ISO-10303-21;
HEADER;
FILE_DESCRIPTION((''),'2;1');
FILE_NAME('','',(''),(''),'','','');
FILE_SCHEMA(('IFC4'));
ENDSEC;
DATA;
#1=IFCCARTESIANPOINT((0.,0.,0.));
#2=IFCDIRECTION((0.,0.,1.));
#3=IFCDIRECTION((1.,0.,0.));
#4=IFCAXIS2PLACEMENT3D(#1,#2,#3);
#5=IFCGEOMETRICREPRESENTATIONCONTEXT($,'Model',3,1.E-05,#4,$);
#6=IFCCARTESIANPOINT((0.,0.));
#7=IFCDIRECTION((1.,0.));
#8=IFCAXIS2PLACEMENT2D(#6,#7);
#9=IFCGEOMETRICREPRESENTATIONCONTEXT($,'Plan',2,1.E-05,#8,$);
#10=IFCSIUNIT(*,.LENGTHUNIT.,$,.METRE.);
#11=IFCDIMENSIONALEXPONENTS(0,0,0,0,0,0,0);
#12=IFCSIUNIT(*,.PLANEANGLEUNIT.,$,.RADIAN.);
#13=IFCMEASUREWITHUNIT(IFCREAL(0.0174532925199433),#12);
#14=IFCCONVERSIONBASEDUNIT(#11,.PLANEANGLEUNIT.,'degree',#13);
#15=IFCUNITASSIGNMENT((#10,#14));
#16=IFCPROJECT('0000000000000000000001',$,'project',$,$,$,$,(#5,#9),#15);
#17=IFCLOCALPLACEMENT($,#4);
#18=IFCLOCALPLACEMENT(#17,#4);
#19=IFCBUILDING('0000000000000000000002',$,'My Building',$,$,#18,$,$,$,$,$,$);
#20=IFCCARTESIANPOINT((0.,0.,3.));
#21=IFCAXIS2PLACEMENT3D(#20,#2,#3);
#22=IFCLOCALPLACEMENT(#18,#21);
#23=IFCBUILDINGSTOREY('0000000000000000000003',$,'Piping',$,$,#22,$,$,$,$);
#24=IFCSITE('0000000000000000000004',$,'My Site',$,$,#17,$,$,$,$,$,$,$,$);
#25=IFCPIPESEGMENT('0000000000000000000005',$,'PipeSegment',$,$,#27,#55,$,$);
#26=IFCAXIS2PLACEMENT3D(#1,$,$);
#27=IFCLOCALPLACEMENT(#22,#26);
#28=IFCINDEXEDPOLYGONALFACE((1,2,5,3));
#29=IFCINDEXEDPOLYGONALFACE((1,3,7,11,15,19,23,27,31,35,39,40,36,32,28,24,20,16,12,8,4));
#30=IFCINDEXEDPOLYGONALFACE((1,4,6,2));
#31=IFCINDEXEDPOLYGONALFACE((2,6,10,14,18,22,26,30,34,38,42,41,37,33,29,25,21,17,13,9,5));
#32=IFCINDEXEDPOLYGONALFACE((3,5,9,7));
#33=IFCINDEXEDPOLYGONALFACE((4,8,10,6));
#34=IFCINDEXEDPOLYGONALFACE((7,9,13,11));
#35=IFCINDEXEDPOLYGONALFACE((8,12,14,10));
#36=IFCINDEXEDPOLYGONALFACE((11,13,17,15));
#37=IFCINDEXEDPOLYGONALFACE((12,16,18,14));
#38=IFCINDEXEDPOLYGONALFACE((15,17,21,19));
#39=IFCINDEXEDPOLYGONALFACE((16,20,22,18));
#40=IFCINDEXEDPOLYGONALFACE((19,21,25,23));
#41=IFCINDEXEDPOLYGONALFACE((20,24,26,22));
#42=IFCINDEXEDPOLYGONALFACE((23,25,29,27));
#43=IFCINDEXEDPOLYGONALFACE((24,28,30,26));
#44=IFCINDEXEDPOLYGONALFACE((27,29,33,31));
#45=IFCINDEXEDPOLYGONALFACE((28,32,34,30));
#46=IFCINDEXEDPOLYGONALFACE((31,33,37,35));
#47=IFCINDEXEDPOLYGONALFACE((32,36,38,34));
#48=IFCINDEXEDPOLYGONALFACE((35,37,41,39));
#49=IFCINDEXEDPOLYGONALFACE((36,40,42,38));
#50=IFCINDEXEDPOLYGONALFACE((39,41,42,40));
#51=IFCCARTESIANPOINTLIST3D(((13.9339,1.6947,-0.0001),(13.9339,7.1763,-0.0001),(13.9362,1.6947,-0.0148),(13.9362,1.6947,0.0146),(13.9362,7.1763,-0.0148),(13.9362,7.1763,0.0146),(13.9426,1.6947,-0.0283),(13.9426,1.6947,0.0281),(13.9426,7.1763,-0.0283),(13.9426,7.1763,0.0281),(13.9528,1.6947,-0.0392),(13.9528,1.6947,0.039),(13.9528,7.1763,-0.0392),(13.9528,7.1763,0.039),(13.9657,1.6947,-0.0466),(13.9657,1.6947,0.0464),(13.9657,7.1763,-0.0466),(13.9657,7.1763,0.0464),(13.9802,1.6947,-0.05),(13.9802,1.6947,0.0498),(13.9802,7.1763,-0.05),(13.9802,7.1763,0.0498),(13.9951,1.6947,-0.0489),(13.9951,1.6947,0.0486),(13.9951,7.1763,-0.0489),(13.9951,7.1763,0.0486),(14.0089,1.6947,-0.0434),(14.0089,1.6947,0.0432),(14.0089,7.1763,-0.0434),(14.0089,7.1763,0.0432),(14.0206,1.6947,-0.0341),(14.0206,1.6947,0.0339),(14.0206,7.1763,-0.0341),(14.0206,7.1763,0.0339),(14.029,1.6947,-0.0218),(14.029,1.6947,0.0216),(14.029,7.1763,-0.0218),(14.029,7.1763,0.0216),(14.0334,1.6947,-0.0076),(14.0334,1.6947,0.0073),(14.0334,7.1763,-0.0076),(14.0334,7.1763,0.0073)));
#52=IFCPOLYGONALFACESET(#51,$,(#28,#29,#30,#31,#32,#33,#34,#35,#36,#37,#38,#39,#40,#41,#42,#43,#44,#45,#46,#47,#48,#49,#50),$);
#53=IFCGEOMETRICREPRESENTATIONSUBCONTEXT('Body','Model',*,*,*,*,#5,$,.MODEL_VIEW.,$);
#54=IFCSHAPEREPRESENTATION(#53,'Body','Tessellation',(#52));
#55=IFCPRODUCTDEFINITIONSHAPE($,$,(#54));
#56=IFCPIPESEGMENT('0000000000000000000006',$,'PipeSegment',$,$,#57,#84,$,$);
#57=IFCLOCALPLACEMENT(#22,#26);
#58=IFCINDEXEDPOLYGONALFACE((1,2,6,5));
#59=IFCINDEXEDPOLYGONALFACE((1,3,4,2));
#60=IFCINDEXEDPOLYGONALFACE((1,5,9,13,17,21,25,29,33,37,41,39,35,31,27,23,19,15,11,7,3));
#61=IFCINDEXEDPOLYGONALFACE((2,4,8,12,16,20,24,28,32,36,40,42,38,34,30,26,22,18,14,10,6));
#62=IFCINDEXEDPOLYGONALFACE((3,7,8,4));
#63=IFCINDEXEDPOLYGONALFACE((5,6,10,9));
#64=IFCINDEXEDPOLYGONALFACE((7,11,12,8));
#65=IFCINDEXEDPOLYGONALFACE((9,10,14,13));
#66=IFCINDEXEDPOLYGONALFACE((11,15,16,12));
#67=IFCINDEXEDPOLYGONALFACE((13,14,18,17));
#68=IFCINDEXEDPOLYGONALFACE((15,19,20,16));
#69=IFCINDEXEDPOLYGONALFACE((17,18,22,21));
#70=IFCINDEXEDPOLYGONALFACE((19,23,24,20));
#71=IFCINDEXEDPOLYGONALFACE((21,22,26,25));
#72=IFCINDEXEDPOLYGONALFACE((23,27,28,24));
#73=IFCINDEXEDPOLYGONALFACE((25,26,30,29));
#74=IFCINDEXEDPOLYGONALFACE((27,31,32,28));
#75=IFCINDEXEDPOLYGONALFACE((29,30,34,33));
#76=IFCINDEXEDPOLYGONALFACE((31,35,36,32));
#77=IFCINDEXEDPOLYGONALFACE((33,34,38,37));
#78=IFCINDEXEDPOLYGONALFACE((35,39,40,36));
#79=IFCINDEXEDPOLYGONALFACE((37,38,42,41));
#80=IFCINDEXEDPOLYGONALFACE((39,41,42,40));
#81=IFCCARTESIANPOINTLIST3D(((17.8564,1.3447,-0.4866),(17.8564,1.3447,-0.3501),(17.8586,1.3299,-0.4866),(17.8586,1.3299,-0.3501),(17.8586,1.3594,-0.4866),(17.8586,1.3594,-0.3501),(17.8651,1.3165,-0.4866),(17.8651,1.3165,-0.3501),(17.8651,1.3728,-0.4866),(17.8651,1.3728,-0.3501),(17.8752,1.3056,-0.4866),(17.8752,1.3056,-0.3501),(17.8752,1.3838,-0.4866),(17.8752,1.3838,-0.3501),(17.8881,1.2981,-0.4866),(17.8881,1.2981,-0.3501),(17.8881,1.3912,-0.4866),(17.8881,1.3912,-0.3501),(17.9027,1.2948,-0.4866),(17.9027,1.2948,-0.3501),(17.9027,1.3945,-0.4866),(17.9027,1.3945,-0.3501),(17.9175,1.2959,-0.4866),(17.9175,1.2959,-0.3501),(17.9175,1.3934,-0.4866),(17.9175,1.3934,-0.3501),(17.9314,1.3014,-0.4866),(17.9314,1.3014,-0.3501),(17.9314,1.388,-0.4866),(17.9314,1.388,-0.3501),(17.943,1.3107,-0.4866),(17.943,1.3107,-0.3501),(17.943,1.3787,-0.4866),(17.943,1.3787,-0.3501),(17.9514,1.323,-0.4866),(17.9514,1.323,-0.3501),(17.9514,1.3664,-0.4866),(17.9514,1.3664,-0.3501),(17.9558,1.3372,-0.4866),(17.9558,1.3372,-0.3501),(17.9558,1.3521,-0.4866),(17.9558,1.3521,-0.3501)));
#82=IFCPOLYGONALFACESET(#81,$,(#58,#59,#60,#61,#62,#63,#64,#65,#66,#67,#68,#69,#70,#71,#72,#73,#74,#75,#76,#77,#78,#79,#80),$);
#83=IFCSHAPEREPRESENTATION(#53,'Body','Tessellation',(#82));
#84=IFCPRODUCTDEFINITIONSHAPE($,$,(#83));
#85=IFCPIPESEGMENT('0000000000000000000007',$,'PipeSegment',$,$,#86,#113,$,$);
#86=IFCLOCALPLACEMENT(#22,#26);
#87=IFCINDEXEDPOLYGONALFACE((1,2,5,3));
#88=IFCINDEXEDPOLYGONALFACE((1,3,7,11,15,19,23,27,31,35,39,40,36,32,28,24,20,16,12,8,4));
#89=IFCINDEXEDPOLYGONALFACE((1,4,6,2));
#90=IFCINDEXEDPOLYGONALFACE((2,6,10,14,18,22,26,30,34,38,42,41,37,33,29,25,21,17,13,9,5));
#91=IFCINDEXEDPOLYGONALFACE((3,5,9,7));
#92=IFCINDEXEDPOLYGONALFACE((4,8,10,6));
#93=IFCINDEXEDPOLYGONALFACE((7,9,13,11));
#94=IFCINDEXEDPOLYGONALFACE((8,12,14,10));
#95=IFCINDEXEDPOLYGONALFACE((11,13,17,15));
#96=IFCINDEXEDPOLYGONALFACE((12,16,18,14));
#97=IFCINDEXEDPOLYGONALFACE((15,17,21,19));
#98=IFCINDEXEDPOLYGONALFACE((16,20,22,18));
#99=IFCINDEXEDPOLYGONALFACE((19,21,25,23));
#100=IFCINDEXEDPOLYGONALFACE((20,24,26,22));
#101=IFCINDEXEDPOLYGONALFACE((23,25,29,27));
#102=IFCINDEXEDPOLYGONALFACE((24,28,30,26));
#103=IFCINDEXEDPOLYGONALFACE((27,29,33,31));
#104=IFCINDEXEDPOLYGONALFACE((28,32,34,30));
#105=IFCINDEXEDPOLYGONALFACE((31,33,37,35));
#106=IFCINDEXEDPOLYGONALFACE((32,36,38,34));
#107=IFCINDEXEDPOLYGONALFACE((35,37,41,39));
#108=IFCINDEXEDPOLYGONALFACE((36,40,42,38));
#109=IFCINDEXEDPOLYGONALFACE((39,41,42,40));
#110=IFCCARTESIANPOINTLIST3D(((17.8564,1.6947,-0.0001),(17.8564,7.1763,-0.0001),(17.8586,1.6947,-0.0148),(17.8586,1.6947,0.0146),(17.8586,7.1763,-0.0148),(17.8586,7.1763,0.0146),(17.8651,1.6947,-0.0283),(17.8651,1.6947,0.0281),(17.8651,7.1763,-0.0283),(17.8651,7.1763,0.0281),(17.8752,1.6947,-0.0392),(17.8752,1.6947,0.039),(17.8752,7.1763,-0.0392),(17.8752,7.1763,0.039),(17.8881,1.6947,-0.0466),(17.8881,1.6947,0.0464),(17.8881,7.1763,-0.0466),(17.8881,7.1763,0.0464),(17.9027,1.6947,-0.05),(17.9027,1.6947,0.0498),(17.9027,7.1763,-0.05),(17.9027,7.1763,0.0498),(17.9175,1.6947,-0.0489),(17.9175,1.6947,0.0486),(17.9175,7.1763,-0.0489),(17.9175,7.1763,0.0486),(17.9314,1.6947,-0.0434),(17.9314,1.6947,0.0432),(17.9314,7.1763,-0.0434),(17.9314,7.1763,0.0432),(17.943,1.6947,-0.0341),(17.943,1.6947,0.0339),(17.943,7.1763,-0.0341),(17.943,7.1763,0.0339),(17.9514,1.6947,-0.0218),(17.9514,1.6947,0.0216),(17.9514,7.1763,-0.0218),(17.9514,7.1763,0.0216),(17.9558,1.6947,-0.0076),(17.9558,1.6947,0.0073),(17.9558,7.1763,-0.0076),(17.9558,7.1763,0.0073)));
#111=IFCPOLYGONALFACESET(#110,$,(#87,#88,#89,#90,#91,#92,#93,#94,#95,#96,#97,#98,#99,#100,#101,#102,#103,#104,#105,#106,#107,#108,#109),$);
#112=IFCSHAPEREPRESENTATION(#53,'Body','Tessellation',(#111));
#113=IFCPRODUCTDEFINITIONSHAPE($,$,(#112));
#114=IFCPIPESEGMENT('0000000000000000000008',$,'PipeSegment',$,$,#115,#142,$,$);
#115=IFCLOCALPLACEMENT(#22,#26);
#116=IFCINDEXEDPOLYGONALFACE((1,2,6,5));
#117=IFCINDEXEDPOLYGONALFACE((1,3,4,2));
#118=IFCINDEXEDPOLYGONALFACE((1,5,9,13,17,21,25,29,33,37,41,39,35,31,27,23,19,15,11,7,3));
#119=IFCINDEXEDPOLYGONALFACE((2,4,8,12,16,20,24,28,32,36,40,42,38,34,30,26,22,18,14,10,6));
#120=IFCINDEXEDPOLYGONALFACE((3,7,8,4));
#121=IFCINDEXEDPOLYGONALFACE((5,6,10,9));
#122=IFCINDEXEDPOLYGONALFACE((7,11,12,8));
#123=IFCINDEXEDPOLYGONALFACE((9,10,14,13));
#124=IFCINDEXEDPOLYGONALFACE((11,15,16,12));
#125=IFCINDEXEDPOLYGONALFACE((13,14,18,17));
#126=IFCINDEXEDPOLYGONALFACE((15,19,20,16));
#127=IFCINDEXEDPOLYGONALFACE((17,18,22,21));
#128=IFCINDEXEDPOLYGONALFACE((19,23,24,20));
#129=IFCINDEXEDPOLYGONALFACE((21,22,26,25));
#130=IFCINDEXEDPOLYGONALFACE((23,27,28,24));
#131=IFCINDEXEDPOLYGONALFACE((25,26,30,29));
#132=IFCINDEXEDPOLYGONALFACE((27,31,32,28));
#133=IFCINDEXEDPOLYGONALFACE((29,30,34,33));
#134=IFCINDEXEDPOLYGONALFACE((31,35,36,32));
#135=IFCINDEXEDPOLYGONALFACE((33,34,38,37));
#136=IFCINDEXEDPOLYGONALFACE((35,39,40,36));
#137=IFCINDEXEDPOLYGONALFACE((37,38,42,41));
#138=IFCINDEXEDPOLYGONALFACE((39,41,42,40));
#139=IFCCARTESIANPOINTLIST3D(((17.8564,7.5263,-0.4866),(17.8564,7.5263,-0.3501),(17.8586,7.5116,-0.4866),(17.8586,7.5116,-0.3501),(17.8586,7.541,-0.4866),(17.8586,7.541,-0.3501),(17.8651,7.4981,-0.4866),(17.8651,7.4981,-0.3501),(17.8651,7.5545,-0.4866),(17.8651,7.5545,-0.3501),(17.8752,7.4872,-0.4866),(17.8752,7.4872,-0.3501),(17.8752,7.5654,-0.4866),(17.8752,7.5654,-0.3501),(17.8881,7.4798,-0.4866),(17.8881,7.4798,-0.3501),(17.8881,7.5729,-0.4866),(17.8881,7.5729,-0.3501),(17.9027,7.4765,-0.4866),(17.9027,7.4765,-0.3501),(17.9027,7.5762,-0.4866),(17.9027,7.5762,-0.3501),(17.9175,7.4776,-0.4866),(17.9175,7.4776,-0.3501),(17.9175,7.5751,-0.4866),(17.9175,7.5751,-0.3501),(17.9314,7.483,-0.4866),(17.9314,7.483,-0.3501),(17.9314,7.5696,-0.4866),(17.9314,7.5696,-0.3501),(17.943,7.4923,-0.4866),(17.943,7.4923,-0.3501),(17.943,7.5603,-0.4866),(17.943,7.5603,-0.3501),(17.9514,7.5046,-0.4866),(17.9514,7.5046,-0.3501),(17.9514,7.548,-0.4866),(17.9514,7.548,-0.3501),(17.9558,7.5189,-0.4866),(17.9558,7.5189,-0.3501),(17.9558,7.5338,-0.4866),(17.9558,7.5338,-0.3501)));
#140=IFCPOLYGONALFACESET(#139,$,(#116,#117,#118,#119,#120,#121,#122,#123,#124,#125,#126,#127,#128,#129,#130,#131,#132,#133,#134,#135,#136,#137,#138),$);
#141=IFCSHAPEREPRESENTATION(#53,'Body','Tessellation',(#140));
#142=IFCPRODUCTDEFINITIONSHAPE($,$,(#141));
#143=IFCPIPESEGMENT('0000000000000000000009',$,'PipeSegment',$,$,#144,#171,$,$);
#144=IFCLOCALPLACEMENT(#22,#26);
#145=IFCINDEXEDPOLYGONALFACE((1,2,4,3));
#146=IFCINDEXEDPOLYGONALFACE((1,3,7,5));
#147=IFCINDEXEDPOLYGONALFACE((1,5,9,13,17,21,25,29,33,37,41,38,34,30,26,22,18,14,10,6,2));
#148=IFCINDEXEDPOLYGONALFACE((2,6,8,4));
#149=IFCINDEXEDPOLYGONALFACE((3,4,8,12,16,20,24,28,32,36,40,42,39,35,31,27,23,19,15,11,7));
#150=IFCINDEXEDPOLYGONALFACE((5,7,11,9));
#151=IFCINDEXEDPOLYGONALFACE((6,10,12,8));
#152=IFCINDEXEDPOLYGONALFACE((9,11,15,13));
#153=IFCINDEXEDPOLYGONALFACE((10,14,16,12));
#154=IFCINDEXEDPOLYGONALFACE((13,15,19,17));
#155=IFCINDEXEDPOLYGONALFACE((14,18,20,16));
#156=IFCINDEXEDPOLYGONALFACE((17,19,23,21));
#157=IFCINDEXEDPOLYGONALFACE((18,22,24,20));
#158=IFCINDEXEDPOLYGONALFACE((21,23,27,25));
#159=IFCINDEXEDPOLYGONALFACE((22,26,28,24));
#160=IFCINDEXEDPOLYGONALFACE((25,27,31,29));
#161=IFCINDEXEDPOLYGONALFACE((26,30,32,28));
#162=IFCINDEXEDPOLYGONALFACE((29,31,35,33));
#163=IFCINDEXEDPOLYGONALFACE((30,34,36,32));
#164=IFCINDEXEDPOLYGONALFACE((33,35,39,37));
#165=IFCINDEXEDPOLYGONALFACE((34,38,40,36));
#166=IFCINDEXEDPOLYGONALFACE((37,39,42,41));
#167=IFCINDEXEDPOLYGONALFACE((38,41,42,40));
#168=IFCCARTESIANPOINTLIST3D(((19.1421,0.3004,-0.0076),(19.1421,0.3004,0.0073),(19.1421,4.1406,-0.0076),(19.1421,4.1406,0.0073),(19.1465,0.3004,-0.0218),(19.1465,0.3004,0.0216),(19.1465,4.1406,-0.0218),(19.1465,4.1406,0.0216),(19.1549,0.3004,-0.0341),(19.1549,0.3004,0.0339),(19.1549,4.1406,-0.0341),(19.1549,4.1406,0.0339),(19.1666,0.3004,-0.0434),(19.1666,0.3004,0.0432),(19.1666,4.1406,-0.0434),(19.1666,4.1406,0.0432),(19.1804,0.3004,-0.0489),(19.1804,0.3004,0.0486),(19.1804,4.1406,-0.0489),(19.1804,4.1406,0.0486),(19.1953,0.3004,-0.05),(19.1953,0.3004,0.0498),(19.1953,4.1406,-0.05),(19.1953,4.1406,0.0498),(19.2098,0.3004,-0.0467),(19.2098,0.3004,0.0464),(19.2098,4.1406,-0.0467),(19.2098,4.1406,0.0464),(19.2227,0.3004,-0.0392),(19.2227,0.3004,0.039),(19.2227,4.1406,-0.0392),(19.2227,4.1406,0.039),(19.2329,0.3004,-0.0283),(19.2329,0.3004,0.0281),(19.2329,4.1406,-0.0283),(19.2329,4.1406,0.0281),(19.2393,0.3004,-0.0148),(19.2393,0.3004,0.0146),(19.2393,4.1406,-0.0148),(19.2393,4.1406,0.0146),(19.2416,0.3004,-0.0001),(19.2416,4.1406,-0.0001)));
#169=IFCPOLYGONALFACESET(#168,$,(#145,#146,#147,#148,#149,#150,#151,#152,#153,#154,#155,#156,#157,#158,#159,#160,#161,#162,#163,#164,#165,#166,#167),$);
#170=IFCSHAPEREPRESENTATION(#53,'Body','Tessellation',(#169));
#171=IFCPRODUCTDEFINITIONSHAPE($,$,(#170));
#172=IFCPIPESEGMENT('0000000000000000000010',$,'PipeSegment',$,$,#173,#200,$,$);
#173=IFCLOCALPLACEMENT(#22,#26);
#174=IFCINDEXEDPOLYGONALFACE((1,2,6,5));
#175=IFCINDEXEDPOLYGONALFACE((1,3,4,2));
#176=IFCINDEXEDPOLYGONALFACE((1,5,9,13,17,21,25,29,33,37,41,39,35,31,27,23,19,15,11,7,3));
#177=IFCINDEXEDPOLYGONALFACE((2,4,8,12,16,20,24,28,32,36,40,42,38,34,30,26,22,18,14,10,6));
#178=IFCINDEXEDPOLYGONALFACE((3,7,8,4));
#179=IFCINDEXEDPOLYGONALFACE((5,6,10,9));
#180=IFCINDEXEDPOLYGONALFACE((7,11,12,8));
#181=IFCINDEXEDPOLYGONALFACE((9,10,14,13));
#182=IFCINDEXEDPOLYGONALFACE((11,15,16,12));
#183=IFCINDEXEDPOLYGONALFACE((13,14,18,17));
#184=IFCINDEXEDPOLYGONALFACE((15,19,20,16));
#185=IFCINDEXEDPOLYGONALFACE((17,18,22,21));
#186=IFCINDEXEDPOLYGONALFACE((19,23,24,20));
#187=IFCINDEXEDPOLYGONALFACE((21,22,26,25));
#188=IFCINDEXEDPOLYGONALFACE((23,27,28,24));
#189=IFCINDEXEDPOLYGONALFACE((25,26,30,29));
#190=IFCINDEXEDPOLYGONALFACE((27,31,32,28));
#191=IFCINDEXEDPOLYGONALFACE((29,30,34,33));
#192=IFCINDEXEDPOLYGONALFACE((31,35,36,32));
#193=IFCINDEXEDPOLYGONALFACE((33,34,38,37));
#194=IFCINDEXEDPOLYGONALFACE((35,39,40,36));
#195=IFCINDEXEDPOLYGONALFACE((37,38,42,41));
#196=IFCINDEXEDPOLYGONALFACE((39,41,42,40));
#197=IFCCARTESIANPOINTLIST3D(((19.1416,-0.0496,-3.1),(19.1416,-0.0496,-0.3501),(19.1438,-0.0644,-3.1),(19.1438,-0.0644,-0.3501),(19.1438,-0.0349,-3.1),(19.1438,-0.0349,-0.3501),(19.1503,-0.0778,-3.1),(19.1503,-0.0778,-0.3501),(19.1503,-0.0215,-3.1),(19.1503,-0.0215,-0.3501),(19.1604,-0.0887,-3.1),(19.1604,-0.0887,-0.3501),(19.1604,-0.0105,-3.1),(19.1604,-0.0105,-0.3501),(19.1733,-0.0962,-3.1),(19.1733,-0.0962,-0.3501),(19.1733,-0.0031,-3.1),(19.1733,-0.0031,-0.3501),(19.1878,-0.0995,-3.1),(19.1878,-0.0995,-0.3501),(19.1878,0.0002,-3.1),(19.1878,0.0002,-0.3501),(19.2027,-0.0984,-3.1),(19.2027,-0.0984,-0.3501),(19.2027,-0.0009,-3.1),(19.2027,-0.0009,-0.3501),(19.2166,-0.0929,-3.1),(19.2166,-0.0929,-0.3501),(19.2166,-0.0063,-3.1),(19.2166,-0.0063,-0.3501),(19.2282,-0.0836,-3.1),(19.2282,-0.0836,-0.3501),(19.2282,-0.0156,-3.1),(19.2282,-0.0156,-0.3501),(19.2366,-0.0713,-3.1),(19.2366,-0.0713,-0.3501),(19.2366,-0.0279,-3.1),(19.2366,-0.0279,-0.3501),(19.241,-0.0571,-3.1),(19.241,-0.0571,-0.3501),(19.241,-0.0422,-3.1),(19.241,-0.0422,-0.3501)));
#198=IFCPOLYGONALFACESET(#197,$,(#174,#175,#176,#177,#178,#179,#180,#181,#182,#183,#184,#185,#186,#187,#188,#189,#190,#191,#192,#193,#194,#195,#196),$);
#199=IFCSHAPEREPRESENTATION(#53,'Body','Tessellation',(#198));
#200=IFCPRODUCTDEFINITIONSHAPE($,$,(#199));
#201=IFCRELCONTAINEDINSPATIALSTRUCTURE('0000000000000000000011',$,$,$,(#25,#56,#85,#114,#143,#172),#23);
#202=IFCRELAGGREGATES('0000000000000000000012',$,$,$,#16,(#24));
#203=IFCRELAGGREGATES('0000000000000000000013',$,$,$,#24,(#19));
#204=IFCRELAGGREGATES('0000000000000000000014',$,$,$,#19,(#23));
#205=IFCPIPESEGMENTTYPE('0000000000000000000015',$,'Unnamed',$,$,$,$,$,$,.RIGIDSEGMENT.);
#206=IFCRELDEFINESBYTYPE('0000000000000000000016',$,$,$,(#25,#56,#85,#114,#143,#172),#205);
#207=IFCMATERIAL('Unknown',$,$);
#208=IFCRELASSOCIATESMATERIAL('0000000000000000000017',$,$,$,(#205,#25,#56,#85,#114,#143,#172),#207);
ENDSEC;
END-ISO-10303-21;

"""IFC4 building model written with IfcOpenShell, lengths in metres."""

from ifc_helpers import new_model, entity, si_unit, converted_unit, frame, origin_with_axes, origin_2d_with_axis, place, context, subcontext, project, spatial, circle, extrude, material, material_profile, profile_set, profile_usage, type_object, element, save


model = new_model("IFC4")

# Units and contexts
model_context = context("Model", 3, precision=1e-05, world=origin_with_axes())
plan_context = context("Plan", 2, precision=1e-05, world=origin_2d_with_axis())
body_context = subcontext(model_context, "Body", "Model", "MODEL_VIEW")
ifc_project = project(units=[si_unit("LENGTHUNIT", "METRE"), converted_unit("PLANEANGLEUNIT", "degree", entity("IfcReal", 0.0174532925199433), si_unit("PLANEANGLEUNIT", "RADIAN"), dimensions=[0, 0, 0, 0, 0, 0, 0])], contexts=[model_context, plan_context])

# Site, building, storey
site_placement = place(None, origin_with_axes())
site = spatial("IfcSite", under=ifc_project, at=site_placement, Name="My Site")
building_placement = place(site_placement, origin_with_axes())
building = spatial("IfcBuilding", under=site, at=building_placement, Name="My Building")
storey_placement = place(building_placement, frame((0.0, 0.0, 3.0), z_axis=(0.0, 0.0, 1.0), x_axis=(1.0, 0.0, 0.0)))
storey = spatial("IfcBuildingStorey", under=building, at=storey_placement, Name="Piping")

# Pipe segments
ifc_material = material(Name="Unknown")
ifc_material_profile = material_profile(ifc_material, circle(Radius=0.05))
ifc_profile_set = profile_set([ifc_material_profile])
pipe_segment_type = type_object("IfcPipeSegmentType", Name="Unnamed", PredefinedType="RIGIDSEGMENT", material=ifc_profile_set)
ifc_profile_usage_1 = profile_usage(ifc_profile_set, cardinal=5)
pipe_segment_1_placement = place(storey_placement, frame((13.9839, 1.6947, -0.0001), z_axis=(0.0, 1.0, 0.0), x_axis=(-1.0, 0.0, 0.0)))
element("IfcPipeSegment", 1, at=pipe_segment_1_placement, inside=storey, type_object=pipe_segment_type, material=ifc_profile_usage_1, Name="PipeSegment", context=body_context, shape_type="SweptSolid", body=[
    extrude(circle(Radius=0.05), origin_with_axes(), (0.0, 0.0, 1.0), 5.4816),
])
ifc_profile_usage_2 = profile_usage(ifc_profile_set, cardinal=5)
pipe_segment_2_placement = place(storey_placement, frame((17.9064, 1.3447, -0.3501), z_axis=(0.0, 0.0, -1.0), x_axis=(-1.0, 0.0, 0.0)))
element("IfcPipeSegment", 2, at=pipe_segment_2_placement, inside=storey, type_object=pipe_segment_type, material=ifc_profile_usage_2, Name="PipeSegment", context=body_context, shape_type="SweptSolid", body=[
    extrude(circle(Radius=0.05), origin_with_axes(), (0.0, 0.0, 1.0), 0.1365),
])
ifc_profile_usage_3 = profile_usage(ifc_profile_set, cardinal=5)
pipe_segment_3_placement = place(storey_placement, frame((17.9064, 1.6947, -0.0001), z_axis=(0.0, 1.0, 0.0), x_axis=(-1.0, 0.0, 0.0)))
element("IfcPipeSegment", 3, at=pipe_segment_3_placement, inside=storey, type_object=pipe_segment_type, material=ifc_profile_usage_3, Name="PipeSegment", context=body_context, shape_type="SweptSolid", body=[
    extrude(circle(Radius=0.05), origin_with_axes(), (0.0, 0.0, 1.0), 5.4816),
])
ifc_profile_usage_4 = profile_usage(ifc_profile_set, cardinal=5)
pipe_segment_4_placement = place(storey_placement, frame((17.9064, 7.5263, -0.3501), z_axis=(0.0, 0.0, -1.0), x_axis=(-1.0, 0.0, 0.0)))
element("IfcPipeSegment", 4, at=pipe_segment_4_placement, inside=storey, type_object=pipe_segment_type, material=ifc_profile_usage_4, Name="PipeSegment", context=body_context, shape_type="SweptSolid", body=[
    extrude(circle(Radius=0.05), origin_with_axes(), (0.0, 0.0, 1.0), 0.1365),
])
ifc_profile_usage_5 = profile_usage(ifc_profile_set, cardinal=5)
pipe_segment_5_placement = place(storey_placement, frame((19.1916, 4.1406, -0.0001), z_axis=(0.0, -1.0, 0.0), x_axis=(1.0, 0.0, 0.0)))
element("IfcPipeSegment", 5, at=pipe_segment_5_placement, inside=storey, type_object=pipe_segment_type, material=ifc_profile_usage_5, Name="PipeSegment", context=body_context, shape_type="SweptSolid", body=[
    extrude(circle(Radius=0.05), origin_with_axes(), (0.0, 0.0, 1.0), 3.8402),
])
ifc_profile_usage_6 = profile_usage(ifc_profile_set, cardinal=5)
pipe_segment_6_placement = place(storey_placement, frame((19.1916, -0.0496, -0.3501), z_axis=(0.0, 0.0, -1.0), x_axis=(-1.0, 0.0, 0.0)))
element("IfcPipeSegment", 6, at=pipe_segment_6_placement, inside=storey, type_object=pipe_segment_type, material=ifc_profile_usage_6, Name="PipeSegment", context=body_context, shape_type="SweptSolid", body=[
    extrude(circle(Radius=0.05), origin_with_axes(), (0.0, 0.0, 1.0), 2.7499),
])

save(model, "model.ifc")
